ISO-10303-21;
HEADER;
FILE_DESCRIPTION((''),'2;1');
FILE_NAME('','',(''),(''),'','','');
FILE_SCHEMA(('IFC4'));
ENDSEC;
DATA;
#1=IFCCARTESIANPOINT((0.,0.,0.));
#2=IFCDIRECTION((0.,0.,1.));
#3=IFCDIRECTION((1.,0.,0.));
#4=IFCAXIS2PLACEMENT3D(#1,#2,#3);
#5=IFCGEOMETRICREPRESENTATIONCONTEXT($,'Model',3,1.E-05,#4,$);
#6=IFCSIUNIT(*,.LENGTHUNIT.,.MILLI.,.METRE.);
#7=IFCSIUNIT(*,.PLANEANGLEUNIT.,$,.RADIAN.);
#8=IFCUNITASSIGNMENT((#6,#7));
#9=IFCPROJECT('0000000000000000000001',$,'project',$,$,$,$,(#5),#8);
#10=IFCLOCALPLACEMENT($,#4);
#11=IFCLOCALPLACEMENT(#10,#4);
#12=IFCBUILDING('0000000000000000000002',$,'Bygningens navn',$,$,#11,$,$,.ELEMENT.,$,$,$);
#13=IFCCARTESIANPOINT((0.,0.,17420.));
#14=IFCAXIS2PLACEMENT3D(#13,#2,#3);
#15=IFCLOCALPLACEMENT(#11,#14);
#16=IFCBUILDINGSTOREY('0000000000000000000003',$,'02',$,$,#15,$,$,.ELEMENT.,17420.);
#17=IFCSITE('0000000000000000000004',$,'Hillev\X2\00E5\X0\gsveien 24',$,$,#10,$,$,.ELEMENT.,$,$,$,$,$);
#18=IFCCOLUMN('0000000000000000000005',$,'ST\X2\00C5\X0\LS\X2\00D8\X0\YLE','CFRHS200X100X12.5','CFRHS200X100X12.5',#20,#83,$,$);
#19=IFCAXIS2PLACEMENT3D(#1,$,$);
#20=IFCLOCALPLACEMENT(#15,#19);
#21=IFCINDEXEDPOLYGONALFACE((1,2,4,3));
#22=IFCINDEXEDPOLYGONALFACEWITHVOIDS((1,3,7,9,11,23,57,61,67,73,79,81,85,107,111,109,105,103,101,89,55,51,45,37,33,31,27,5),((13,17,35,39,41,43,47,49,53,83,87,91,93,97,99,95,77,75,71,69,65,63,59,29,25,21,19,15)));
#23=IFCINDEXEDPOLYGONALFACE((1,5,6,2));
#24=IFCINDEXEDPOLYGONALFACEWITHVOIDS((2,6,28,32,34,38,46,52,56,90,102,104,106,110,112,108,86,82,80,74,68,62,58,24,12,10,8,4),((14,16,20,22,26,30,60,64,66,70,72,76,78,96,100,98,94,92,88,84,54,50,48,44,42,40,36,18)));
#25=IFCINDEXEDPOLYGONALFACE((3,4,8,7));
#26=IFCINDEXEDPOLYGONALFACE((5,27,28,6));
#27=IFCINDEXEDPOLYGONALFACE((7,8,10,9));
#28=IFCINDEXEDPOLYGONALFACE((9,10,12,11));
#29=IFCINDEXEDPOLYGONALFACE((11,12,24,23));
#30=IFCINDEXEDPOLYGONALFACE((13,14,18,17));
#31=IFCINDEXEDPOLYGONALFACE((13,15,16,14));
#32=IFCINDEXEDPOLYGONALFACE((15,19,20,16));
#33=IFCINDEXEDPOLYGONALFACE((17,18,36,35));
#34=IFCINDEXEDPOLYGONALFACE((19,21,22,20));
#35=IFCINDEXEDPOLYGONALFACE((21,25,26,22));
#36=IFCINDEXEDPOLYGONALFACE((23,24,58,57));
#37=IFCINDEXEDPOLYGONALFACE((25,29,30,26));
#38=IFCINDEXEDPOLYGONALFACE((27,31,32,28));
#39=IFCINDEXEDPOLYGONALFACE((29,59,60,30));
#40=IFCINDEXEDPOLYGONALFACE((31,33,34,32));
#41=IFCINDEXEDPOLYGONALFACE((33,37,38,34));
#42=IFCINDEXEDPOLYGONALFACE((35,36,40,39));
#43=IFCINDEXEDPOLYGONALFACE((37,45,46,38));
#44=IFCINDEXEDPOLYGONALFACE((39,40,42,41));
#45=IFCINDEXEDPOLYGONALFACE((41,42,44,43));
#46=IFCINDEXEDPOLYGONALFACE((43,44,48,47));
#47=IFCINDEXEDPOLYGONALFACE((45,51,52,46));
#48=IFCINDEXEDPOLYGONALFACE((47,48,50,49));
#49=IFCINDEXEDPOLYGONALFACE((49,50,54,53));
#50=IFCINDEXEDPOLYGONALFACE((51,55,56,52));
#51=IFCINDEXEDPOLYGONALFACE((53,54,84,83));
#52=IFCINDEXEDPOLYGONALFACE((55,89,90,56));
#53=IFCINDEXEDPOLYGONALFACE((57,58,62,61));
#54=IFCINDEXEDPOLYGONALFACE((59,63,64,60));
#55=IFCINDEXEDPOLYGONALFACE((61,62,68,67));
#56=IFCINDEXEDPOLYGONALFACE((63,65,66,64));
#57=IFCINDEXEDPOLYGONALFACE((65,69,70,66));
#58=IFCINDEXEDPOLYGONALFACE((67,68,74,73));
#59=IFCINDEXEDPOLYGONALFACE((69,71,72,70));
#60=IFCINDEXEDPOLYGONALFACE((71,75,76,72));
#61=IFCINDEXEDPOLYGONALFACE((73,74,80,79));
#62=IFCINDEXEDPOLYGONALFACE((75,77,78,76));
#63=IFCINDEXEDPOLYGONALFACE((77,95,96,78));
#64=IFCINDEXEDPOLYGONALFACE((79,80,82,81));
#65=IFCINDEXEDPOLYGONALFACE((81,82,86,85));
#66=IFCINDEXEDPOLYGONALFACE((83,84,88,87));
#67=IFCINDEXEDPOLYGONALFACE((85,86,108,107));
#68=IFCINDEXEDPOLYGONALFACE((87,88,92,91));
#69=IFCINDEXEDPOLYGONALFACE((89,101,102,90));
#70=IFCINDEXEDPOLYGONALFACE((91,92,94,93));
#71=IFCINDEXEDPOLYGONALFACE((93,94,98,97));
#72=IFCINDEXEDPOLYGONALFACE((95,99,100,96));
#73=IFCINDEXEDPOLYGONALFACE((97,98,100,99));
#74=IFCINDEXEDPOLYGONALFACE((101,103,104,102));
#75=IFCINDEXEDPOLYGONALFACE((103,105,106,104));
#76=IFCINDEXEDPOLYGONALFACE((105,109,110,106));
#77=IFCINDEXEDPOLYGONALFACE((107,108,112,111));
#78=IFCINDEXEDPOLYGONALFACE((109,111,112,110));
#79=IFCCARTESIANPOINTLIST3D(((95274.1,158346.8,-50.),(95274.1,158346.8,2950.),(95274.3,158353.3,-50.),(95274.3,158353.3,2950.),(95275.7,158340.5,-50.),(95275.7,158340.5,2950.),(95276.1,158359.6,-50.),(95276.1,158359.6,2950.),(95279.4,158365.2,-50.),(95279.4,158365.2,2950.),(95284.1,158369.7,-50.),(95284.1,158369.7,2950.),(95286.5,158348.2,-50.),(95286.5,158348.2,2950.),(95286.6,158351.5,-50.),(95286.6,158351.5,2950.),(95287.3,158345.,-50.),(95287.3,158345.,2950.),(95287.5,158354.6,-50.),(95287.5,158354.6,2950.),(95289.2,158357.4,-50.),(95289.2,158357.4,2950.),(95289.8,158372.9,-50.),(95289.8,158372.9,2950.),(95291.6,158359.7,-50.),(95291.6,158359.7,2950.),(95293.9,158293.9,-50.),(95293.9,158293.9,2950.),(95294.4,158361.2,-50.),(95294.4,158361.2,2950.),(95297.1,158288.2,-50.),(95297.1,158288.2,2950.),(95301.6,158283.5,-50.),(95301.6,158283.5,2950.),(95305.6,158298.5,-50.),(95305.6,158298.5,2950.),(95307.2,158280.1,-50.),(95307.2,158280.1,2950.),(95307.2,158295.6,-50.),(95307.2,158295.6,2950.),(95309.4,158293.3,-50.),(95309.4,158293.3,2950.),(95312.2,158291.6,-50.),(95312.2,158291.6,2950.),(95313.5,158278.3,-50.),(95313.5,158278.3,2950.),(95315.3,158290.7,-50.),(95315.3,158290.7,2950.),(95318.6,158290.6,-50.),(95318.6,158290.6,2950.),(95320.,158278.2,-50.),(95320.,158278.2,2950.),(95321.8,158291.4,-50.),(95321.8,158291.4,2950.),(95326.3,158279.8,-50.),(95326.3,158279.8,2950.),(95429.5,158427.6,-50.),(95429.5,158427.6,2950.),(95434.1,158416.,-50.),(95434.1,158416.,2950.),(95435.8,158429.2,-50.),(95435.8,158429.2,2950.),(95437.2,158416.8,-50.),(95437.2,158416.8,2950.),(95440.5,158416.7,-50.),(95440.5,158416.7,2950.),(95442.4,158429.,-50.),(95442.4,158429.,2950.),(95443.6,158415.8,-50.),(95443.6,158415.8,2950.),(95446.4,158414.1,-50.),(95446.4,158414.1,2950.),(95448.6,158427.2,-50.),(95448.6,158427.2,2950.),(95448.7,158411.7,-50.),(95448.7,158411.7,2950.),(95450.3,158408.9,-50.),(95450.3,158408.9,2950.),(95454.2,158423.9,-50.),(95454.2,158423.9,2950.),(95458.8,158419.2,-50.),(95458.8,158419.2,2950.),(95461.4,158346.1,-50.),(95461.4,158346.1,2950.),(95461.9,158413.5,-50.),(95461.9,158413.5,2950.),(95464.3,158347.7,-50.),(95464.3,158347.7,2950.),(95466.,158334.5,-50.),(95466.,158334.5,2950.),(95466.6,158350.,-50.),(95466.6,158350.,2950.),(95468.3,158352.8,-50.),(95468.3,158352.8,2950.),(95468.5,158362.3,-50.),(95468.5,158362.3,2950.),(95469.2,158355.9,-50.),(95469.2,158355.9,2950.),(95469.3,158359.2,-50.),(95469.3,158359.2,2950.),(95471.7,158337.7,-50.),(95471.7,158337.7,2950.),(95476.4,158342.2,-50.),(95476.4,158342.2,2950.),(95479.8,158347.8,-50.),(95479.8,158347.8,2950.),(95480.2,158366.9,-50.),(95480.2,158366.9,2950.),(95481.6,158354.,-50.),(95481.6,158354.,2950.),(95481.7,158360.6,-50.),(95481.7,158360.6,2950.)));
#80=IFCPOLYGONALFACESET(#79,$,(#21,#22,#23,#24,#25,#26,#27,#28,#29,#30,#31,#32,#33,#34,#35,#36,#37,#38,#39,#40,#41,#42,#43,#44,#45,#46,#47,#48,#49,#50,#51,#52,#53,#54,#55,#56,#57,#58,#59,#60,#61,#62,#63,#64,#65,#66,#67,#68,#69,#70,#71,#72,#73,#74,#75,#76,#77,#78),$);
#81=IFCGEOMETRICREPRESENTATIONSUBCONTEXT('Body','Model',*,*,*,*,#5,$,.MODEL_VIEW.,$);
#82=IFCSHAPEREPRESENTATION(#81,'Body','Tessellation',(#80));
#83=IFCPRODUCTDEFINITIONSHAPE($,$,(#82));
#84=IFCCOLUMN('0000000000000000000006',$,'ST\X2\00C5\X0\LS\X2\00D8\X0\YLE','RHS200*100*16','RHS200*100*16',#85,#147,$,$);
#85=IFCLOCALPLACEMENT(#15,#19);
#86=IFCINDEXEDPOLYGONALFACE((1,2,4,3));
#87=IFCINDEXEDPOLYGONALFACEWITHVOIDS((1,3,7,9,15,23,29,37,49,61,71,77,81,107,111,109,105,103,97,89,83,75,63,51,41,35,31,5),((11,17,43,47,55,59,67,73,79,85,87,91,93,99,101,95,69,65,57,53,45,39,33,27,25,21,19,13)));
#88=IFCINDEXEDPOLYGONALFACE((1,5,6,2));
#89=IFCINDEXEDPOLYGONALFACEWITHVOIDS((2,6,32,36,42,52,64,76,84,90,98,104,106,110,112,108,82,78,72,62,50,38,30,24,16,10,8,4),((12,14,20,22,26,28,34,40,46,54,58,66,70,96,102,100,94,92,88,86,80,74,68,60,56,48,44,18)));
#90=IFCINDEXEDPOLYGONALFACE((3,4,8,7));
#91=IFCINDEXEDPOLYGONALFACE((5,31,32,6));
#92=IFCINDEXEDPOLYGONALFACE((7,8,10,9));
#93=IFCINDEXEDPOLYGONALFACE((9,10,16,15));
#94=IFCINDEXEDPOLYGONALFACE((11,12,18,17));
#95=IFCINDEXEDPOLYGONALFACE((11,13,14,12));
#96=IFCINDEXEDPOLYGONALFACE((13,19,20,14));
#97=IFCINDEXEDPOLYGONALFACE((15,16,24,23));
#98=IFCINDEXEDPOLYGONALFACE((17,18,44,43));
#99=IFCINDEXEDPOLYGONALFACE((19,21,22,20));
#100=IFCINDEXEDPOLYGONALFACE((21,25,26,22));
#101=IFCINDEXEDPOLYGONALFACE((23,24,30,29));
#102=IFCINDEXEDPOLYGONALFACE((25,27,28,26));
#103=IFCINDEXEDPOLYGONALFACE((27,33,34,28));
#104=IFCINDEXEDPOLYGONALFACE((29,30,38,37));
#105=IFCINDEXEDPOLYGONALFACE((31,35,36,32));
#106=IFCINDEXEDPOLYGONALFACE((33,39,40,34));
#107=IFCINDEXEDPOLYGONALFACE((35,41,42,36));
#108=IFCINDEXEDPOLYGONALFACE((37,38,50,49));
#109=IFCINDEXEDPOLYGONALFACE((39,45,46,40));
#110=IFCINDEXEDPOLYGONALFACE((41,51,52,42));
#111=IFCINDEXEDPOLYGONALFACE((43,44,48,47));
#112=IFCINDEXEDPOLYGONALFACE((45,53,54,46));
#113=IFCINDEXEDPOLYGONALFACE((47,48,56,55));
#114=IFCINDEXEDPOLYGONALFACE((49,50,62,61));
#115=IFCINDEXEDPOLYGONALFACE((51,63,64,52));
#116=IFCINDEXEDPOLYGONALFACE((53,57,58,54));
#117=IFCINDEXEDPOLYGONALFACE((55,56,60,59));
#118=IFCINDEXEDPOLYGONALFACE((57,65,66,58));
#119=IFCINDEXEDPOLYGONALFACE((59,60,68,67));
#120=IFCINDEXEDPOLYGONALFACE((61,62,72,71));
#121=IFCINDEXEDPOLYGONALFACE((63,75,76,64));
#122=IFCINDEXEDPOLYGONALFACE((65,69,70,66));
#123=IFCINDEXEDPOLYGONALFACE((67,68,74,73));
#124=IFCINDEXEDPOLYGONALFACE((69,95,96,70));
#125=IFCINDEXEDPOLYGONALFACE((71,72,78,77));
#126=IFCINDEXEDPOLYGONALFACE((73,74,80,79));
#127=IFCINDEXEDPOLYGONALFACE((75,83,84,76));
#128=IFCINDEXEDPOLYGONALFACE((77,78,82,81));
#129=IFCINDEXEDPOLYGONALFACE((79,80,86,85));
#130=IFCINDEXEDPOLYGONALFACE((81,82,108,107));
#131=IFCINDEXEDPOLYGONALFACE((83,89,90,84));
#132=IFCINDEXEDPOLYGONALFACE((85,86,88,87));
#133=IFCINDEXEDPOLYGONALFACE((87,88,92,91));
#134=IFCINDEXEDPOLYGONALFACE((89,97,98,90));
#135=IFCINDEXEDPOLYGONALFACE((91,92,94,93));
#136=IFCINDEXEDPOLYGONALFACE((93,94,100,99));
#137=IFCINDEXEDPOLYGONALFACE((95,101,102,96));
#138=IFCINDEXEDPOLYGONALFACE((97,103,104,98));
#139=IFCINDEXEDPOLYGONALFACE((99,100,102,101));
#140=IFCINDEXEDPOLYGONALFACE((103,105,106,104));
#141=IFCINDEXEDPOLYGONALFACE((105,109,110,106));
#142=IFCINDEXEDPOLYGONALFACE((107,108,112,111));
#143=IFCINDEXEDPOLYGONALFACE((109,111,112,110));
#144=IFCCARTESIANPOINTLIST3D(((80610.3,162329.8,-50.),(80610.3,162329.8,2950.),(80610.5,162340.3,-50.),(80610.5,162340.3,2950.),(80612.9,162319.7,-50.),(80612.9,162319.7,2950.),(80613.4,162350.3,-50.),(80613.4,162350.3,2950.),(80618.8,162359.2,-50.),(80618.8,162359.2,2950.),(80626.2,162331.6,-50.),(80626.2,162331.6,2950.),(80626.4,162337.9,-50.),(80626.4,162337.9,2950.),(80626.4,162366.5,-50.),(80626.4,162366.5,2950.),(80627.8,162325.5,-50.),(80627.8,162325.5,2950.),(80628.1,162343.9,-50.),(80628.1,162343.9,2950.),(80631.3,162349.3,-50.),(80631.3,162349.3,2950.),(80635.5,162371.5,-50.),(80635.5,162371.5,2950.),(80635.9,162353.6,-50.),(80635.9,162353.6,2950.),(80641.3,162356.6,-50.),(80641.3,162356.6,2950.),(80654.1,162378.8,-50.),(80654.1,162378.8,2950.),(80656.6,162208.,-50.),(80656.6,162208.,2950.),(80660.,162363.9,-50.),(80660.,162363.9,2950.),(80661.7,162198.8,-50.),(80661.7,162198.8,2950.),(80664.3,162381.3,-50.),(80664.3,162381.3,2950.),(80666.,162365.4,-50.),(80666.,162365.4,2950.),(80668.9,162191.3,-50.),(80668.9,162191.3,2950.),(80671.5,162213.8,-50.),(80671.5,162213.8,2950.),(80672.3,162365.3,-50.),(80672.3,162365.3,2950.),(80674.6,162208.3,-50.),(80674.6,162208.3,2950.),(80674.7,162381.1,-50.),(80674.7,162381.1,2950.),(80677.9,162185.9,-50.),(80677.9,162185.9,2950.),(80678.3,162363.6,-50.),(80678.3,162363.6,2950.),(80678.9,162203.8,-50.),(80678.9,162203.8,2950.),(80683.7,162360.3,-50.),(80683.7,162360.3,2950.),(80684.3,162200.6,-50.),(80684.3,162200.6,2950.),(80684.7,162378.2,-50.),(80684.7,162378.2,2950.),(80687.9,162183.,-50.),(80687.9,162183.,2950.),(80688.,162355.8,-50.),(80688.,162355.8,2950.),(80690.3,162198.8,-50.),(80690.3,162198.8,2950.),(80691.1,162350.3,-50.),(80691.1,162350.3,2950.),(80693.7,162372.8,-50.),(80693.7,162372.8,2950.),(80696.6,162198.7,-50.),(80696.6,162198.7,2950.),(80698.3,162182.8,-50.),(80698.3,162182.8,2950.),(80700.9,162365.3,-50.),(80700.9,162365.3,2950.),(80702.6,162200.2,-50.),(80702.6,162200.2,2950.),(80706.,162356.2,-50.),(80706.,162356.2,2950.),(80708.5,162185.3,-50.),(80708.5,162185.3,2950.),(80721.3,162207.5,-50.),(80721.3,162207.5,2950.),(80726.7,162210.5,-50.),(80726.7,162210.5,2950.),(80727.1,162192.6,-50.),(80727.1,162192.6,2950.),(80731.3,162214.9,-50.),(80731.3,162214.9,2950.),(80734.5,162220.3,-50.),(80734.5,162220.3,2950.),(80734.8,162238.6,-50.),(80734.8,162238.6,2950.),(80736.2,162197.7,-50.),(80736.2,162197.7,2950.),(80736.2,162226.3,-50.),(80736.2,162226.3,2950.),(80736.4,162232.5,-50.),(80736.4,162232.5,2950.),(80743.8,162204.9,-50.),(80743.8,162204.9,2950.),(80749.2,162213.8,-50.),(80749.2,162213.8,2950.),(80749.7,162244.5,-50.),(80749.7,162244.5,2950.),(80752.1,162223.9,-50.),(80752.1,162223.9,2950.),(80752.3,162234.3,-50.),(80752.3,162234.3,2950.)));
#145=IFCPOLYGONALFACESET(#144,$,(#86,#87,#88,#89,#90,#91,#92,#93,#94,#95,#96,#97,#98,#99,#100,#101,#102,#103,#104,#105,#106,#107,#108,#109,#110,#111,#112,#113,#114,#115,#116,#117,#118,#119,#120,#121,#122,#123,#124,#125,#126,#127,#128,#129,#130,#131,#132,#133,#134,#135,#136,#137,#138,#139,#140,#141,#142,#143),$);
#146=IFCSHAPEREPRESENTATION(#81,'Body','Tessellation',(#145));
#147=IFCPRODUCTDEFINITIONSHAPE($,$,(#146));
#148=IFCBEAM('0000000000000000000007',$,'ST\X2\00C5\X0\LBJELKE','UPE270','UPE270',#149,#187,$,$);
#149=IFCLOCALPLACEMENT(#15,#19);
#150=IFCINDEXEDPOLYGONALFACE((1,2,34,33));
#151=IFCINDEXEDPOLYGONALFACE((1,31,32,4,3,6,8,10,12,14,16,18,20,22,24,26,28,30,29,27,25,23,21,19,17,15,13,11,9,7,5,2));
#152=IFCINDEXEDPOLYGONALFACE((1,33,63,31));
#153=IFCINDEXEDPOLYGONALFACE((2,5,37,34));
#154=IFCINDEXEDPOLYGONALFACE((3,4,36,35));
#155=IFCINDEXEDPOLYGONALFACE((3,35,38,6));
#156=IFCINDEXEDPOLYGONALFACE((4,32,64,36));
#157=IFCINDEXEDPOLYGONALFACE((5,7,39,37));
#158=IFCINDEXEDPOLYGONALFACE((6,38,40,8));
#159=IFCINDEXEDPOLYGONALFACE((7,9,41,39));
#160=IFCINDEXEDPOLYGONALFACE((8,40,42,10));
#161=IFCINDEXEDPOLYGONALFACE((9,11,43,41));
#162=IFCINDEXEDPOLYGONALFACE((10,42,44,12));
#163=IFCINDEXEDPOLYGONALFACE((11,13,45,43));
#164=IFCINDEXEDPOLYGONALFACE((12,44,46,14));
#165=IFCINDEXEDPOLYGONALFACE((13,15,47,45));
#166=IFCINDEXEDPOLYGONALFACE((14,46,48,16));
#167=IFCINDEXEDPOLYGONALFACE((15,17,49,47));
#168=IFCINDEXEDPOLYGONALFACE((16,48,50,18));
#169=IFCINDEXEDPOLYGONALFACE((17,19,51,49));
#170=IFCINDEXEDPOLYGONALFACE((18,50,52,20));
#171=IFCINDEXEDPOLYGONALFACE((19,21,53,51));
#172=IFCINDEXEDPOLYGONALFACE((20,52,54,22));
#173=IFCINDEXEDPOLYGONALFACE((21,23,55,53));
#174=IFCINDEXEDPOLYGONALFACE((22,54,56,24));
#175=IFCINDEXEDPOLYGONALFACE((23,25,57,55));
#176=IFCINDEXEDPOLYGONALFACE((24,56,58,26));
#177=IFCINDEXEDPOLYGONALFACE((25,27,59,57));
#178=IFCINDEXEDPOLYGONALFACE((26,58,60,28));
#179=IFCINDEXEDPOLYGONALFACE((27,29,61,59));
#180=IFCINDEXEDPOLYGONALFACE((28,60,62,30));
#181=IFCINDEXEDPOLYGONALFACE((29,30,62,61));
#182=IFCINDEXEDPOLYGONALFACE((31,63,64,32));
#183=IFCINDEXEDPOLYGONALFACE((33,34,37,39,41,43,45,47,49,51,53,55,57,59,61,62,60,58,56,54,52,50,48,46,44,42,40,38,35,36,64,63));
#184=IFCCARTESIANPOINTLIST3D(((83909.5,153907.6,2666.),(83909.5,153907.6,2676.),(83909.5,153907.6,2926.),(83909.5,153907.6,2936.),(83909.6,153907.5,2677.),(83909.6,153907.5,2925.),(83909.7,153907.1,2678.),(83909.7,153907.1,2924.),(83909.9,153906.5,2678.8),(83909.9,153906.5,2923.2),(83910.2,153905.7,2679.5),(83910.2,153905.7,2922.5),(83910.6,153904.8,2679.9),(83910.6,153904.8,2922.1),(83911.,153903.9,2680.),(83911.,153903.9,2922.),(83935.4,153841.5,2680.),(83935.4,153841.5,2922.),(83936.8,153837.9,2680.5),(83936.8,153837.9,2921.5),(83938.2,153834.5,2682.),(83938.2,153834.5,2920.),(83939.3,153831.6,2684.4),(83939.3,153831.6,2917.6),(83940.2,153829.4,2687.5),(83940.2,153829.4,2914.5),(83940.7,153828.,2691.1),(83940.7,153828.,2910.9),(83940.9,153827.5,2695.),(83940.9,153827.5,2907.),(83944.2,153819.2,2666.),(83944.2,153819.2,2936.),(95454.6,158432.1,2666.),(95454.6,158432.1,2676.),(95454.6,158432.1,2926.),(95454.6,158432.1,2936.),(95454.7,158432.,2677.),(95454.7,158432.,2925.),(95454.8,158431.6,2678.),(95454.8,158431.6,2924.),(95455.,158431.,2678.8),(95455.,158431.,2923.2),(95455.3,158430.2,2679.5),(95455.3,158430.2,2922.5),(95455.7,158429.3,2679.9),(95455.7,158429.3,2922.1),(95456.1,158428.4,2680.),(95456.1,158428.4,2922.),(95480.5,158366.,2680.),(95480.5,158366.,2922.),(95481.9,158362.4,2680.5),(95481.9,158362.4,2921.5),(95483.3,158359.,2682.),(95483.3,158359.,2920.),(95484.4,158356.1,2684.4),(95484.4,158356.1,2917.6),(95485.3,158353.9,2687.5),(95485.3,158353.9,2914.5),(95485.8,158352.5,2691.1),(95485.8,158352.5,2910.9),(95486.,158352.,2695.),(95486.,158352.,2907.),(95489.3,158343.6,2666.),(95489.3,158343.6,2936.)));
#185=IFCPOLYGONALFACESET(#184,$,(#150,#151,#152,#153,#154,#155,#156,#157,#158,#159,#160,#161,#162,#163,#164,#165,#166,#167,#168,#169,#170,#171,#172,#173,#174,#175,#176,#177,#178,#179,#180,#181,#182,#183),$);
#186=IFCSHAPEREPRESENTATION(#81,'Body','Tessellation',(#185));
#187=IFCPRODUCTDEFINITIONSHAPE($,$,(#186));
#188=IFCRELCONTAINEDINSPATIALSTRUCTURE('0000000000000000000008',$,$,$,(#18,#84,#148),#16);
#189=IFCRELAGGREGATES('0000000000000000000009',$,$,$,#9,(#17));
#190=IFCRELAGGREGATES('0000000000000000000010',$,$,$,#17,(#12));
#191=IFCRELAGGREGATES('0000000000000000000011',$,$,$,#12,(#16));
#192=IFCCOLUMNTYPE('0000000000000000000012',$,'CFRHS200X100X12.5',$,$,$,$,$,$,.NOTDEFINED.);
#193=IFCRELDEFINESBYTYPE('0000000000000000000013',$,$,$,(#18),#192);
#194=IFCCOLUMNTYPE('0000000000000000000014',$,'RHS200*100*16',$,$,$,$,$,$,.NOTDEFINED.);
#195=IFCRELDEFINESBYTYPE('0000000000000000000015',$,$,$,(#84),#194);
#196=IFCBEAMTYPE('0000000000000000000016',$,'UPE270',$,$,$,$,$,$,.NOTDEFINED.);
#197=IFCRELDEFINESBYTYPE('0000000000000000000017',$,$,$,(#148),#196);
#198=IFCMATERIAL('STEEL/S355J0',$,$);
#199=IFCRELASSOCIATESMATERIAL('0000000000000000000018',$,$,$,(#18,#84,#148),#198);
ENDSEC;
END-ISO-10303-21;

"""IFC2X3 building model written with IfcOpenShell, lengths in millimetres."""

from ifc_helpers import new_model, si_unit, frame, frame_2d, origin_with_axes, place, context, subcontext, project, spatial, hollow_rectangle, u_section, extrude, material, type_object, element, save


model = new_model("IFC2X3")

# Units and contexts
model_context = context("Model", 3, precision=1e-05, world=origin_with_axes())
body_context = subcontext(model_context, "Body", "Model", "MODEL_VIEW")
ifc_project = project(units=[si_unit("LENGTHUNIT", "METRE", prefix="MILLI"), si_unit("PLANEANGLEUNIT", "RADIAN")], contexts=[model_context])

# Site, building, storey
site_placement = place(None, origin_with_axes())
site = spatial("IfcSite", under=ifc_project, at=site_placement, Name="Hillevågsveien 24", CompositionType="ELEMENT")
building_placement = place(site_placement, origin_with_axes())
building = spatial("IfcBuilding", under=site, at=building_placement, Name="Bygningens navn", CompositionType="ELEMENT")
storey_placement = place(building_placement, frame((0.0, 0.0, 17420.0), z_axis=(0.0, 0.0, 1.0), x_axis=(1.0, 0.0, 0.0)))
storey = spatial("IfcBuildingStorey", under=building, at=storey_placement, Name="02", CompositionType="ELEMENT", Elevation=17420.0)

# Columns
ifc_material_1 = material(Name="STEEL/S355J0")
column_type_1 = type_object("IfcColumnType", Name="CFRHS200X100X12.5", PredefinedType="NOTDEFINED")
for number, where, z_axis, x_axis, name in (
    (1, (95377.9, 158353.7, -50.0), (0.0, 0.0, 1.0), (0.931056, 0.364877, 0.0), "STÅLSØYLE"),
):
    element("IfcColumn", number, at=place(storey_placement, frame(where, z_axis=z_axis, x_axis=x_axis)), inside=storey, type_object=column_type_1, material=ifc_material_1, Name=name, Description="CFRHS200X100X12.5", ObjectType="CFRHS200X100X12.5", context=body_context, shape_type="SweptSolid", body=[
        extrude(hollow_rectangle(XDim=100.0, YDim=200.0, WallThickness=12.5, InnerFilletRadius=12.5, OuterFilletRadius=25.0, at=frame_2d((0.0, 0.0), x_axis=(1.0, 0.0))), frame((0.0, 0.0, 3000.0), z_axis=(0.0, 0.0, -1.0), x_axis=(0.0, 1.0, 0.0)), (0.0, 0.0, 1.0), 3000.0),
    ])
column_type_2 = type_object("IfcColumnType", Name="RHS200*100*16", PredefinedType="NOTDEFINED")
column_placement = place(storey_placement, frame((80681.3, 162282.1, -50.0), z_axis=(0.0, 0.0, 1.0), x_axis=(0.364877, -0.931056, 0.0)))
element("IfcColumn", 2, at=column_placement, inside=storey, type_object=column_type_2, material=ifc_material_1, Name="STÅLSØYLE", Description="RHS200*100*16", ObjectType="RHS200*100*16", context=body_context, shape_type="SweptSolid", body=[
    extrude(hollow_rectangle(XDim=100.0, YDim=200.0, WallThickness=16.0, InnerFilletRadius=24.0, OuterFilletRadius=40.0, at=frame_2d((0.0, 0.0), x_axis=(1.0, 0.0))), frame((0.0, 0.0, 3000.0), z_axis=(0.0, 0.0, -1.0), x_axis=(0.0, 1.0, 0.0)), (0.0, 0.0, 1.0), 3000.0),
])

# Beam
beam_type_1 = type_object("IfcBeamType", Name="UPE270", PredefinedType="NOTDEFINED")
beam_1_placement = place(storey_placement, frame((83926.8, 153863.4, 2801.0), z_axis=(0.0, 0.0, -1.0), x_axis=(0.931056, 0.364877, 0.0)))
element("IfcBeam", 3, at=beam_1_placement, inside=storey, type_object=beam_type_1, material=ifc_material_1, Name="STÅLBJELKE", Description="UPE270", ObjectType="UPE270", context=body_context, shape_type="SweptSolid", body=[
    extrude(u_section(Depth=270.0, FlangeWidth=95.0, WebThickness=9.0, FlangeThickness=14.0, FilletRadius=15.0, EdgeRadius=4.0, at=frame_2d((0.0, 0.0), x_axis=(1.0, 0.0))), frame((12400.0, 0.0, 0.0), z_axis=(-1.0, 0.0, 0.0), x_axis=(0.0, -1.0, 0.0)), (0.0, 0.0, 1.0), 12400.0),
])

save(model, "model.ifc")
